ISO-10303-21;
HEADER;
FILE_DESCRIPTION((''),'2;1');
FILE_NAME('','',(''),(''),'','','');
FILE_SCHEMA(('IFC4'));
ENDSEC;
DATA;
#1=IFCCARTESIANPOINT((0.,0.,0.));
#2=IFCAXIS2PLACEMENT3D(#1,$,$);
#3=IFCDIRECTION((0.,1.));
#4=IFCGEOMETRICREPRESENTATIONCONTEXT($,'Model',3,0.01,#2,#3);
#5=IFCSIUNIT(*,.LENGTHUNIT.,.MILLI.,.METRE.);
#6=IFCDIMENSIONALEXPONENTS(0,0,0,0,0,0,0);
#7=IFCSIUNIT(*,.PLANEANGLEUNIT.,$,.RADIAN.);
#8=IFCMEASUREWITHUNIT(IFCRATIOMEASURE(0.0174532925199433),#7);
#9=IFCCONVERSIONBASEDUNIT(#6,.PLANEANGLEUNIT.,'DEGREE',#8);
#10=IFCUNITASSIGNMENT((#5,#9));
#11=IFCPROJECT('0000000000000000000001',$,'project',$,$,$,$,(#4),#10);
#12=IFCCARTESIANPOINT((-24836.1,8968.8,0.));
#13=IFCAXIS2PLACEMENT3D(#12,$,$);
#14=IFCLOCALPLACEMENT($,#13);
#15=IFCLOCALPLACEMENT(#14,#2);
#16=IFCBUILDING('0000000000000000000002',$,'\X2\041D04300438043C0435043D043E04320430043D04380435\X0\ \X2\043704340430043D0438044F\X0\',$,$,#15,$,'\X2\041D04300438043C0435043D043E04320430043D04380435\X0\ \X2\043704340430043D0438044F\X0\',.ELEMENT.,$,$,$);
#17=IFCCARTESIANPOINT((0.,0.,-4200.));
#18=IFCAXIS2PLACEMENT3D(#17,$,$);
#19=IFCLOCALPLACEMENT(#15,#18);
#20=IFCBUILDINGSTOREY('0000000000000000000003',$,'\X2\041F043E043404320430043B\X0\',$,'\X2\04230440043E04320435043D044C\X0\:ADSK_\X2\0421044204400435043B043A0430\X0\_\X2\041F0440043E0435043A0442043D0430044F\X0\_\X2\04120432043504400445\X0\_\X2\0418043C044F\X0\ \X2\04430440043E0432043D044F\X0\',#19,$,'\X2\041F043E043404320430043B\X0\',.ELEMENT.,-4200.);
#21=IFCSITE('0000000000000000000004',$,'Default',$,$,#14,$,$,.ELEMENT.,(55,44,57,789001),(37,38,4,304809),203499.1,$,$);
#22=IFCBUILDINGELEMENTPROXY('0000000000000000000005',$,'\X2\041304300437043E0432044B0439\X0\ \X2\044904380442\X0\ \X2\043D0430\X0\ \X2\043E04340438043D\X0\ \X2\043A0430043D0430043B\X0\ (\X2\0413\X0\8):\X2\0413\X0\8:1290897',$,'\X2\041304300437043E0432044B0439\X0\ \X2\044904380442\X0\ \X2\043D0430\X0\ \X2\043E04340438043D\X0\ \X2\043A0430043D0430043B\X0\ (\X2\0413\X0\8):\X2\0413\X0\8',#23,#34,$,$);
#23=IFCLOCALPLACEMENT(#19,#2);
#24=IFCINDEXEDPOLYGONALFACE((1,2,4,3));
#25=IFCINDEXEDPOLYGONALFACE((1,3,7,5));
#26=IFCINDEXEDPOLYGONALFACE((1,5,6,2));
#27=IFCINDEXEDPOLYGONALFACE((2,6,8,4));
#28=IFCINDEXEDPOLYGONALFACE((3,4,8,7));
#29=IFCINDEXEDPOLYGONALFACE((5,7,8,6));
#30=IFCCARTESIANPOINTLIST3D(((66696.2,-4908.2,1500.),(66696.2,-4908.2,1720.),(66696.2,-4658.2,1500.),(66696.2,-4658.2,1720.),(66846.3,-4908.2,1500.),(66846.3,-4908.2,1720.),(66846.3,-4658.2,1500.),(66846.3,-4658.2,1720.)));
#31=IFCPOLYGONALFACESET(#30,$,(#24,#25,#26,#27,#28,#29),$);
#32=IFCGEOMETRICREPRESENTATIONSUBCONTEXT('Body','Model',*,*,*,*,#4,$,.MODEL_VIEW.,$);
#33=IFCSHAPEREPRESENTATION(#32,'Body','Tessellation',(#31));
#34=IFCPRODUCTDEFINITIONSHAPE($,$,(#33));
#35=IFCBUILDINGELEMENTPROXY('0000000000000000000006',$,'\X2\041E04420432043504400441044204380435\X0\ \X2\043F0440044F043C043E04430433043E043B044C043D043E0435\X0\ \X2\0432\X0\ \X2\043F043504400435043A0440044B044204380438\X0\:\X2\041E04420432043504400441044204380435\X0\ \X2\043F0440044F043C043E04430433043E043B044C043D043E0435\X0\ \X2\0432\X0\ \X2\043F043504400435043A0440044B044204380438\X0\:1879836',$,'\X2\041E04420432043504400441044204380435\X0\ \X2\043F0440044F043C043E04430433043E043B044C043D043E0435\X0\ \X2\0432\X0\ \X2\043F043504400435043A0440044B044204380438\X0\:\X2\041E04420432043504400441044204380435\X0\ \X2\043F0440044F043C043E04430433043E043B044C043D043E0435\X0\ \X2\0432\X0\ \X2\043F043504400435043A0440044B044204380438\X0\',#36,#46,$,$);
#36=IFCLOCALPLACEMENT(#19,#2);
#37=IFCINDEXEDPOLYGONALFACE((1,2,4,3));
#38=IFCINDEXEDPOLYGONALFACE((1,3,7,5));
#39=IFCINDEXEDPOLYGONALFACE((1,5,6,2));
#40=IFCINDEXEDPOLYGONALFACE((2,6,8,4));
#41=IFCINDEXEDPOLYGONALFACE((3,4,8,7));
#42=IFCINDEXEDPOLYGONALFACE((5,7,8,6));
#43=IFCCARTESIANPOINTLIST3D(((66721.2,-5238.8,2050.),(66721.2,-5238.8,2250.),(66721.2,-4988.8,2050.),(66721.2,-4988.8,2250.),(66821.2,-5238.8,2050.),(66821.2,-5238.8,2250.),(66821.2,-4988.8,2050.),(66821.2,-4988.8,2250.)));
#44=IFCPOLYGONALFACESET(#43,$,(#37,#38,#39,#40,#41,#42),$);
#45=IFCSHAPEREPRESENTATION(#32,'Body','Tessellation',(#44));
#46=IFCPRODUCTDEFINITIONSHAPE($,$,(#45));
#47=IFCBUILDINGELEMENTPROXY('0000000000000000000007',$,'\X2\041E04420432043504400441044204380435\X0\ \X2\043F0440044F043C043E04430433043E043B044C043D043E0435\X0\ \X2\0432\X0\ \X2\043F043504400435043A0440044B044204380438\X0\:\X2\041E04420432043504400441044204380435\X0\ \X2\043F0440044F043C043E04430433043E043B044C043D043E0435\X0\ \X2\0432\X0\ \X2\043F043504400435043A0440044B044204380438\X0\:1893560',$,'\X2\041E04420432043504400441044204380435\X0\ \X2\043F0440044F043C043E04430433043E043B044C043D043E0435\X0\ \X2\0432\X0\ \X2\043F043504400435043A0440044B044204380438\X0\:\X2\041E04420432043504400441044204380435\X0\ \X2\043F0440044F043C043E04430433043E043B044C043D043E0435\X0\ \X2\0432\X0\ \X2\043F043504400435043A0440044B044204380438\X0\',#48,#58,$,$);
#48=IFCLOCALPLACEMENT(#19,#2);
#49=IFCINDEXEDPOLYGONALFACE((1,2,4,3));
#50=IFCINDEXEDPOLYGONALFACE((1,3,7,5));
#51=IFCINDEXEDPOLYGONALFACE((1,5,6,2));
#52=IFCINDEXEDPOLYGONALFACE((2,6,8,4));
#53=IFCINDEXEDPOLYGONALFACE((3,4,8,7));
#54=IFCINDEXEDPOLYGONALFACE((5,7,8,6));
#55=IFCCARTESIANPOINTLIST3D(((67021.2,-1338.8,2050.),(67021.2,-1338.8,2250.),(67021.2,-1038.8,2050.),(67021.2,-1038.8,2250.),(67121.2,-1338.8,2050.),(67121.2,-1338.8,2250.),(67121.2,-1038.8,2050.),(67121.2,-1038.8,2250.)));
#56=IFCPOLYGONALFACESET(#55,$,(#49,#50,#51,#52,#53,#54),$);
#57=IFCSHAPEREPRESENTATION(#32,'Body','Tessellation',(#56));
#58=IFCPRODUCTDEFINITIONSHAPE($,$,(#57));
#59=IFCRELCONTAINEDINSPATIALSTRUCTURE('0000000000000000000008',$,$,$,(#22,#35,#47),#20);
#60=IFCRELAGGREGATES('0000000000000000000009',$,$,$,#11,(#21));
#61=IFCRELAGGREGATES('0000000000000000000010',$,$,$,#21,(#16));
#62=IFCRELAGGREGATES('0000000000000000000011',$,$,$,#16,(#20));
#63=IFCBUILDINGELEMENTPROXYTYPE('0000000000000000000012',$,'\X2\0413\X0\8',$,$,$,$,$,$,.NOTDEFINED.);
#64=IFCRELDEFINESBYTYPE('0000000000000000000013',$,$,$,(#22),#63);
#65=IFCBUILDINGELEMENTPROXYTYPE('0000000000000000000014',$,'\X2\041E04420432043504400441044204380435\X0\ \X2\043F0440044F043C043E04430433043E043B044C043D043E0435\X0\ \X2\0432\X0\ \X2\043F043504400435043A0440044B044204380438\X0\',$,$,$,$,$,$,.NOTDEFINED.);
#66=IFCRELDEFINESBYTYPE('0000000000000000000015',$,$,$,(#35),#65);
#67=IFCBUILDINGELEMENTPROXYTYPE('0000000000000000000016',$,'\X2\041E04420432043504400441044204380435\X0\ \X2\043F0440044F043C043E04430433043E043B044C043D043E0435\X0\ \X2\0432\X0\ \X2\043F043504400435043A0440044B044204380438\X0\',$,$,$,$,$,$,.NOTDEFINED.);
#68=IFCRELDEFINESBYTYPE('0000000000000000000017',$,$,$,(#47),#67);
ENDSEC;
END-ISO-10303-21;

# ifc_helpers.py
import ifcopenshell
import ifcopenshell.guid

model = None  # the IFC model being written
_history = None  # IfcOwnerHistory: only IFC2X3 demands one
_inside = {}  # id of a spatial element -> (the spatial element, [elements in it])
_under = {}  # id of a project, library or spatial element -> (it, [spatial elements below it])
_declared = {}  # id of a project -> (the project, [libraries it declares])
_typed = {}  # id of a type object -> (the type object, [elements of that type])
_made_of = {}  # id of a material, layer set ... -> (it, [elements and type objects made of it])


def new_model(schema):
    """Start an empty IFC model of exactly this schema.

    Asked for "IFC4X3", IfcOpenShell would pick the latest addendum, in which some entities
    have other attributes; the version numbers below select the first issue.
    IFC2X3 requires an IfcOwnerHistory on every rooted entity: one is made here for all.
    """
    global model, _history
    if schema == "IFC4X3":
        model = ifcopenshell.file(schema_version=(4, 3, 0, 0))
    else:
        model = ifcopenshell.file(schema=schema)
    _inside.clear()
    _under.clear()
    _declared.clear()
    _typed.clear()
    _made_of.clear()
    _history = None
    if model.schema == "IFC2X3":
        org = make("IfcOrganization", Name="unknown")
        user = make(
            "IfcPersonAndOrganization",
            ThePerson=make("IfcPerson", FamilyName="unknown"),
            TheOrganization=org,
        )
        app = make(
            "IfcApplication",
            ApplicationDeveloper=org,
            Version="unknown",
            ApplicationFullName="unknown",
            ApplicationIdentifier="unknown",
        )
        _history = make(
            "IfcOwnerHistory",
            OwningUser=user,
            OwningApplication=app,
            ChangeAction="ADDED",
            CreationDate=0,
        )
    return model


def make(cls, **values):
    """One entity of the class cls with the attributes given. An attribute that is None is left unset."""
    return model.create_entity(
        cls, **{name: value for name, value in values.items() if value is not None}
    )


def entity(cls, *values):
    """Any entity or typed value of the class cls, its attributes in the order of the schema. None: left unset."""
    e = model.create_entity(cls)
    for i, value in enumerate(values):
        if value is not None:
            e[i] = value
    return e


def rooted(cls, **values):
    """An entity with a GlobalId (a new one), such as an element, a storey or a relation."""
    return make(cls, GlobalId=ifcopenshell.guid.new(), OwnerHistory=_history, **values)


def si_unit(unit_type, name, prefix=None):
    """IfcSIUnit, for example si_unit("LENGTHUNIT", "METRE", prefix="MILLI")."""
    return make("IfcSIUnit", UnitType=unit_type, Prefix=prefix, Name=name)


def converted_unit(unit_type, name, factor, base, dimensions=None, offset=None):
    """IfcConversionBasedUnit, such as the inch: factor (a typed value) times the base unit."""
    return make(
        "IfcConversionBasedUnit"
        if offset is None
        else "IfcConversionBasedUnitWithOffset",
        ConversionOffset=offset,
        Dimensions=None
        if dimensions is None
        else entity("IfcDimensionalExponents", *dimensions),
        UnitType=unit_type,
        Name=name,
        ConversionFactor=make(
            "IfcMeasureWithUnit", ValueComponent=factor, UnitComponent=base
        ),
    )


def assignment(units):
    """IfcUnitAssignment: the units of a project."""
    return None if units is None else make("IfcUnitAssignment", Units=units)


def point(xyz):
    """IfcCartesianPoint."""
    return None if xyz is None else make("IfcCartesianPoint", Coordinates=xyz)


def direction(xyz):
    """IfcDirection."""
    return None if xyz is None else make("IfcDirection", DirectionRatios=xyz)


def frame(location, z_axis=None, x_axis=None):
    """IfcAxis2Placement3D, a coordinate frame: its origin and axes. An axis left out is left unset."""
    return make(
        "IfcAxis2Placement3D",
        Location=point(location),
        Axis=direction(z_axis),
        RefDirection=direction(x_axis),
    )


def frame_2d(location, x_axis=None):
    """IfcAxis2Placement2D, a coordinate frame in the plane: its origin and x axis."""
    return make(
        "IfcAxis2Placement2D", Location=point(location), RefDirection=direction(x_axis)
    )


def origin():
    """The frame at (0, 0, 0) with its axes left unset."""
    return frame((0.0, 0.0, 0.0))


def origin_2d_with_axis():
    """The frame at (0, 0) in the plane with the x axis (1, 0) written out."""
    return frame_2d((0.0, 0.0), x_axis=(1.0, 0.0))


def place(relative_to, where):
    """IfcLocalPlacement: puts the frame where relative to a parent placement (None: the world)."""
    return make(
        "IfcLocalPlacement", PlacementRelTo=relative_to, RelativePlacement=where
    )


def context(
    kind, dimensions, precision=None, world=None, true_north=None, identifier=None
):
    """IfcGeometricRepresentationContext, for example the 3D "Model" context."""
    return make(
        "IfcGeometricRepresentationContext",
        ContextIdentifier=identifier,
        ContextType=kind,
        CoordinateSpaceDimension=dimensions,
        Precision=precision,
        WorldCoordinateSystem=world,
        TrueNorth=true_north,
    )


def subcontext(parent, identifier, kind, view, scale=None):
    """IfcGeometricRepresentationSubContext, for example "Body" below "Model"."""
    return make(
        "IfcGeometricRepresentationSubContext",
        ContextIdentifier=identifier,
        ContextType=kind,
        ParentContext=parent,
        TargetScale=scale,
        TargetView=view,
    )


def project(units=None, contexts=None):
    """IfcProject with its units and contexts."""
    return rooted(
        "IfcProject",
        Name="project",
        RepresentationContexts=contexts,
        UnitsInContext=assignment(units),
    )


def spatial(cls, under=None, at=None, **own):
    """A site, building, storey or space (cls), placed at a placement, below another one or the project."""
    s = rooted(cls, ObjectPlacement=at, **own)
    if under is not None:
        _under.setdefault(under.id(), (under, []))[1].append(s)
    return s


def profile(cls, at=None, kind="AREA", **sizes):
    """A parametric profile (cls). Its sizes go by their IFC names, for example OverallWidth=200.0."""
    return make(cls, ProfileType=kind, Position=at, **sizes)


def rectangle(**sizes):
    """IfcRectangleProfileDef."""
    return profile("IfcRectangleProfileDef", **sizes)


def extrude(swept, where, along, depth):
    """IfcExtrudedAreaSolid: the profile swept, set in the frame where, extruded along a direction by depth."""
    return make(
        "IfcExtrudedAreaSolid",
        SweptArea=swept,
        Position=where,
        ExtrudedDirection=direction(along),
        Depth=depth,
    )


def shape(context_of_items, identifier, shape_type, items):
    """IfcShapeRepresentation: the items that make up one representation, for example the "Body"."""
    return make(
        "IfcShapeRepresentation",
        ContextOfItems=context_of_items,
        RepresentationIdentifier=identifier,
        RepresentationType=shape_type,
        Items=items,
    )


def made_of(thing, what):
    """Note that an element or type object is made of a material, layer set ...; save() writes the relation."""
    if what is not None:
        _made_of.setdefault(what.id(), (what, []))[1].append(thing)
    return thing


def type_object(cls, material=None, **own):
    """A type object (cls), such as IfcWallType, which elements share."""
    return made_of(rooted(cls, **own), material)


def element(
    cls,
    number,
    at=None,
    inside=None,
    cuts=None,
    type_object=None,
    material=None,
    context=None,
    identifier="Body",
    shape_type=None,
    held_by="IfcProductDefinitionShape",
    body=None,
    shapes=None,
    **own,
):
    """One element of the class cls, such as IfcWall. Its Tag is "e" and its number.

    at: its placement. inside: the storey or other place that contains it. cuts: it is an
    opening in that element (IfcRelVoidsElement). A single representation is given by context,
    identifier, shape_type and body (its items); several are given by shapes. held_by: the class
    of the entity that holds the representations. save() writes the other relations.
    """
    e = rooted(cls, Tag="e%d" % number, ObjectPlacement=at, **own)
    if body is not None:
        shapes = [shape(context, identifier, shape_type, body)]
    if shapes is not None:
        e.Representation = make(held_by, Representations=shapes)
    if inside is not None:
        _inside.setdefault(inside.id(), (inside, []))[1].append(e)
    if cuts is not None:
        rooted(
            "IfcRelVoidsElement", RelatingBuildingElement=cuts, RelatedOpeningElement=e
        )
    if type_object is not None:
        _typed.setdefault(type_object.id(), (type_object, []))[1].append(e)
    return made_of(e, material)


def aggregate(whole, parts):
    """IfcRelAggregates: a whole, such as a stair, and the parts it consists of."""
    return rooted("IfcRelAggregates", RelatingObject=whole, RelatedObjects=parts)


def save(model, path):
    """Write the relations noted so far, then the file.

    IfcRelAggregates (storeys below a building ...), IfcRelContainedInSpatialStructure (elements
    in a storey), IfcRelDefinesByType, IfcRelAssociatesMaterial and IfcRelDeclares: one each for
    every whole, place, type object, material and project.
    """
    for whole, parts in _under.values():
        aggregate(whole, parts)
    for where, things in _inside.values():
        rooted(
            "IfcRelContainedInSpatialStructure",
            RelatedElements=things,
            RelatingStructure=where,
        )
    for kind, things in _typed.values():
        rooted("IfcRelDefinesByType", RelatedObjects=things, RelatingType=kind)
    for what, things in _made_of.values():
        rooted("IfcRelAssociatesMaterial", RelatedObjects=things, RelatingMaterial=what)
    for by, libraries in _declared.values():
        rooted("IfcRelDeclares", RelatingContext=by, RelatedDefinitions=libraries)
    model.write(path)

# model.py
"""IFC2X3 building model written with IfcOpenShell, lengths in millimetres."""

from ifc_helpers import new_model, entity, si_unit, converted_unit, direction, frame, origin, origin_2d_with_axis, place, context, subcontext, project, spatial, rectangle, extrude, type_object, element, save


model = new_model("IFC2X3")

# Units and contexts
model_context = context("Model", 3, precision=0.01, world=origin(), true_north=direction((0.0, 1.0)))
body_context = subcontext(model_context, "Body", "Model", "MODEL_VIEW")
ifc_project = project(units=[si_unit("LENGTHUNIT", "METRE", prefix="MILLI"), converted_unit("PLANEANGLEUNIT", "DEGREE", entity("IfcRatioMeasure", 0.0174532925199433), si_unit("PLANEANGLEUNIT", "RADIAN"), dimensions=[0, 0, 0, 0, 0, 0, 0])], contexts=[model_context])

# Site, building, storey
site_placement = place(None, frame((-24836.1, 8968.8, 0.0)))
site = spatial("IfcSite", under=ifc_project, at=site_placement, Name="Default", CompositionType="ELEMENT", RefLatitude=(55, 44, 57, 789001), RefLongitude=(37, 38, 4, 304809), RefElevation=203499.1)
building_placement = place(site_placement, origin())
building = spatial("IfcBuilding", under=site, at=building_placement, Name="Наименование здания", LongName="Наименование здания", CompositionType="ELEMENT")
storey_placement = place(building_placement, frame((0.0, 0.0, -4200.0)))
storey = spatial("IfcBuildingStorey", under=building, at=storey_placement, Name="Подвал", ObjectType="Уровень:ADSK_Стрелка_Проектная_Вверх_Имя уровня", LongName="Подвал", CompositionType="ELEMENT", Elevation=-4200.0)

# Building element proxies
building_element_proxy_type_1 = type_object("IfcBuildingElementProxyType", Name="Г8", PredefinedType="NOTDEFINED")
proxy_1_placement = place(storey_placement, frame((66696.2, -4908.1, 1500.0)))
element("IfcBuildingElementProxy", 1, at=proxy_1_placement, inside=storey, type_object=building_element_proxy_type_1, Name="Газовый щит на один канал (Г8):Г8:1290897", ObjectType="Газовый щит на один канал (Г8):Г8", context=body_context, shape_type="SweptSolid", body=[
    extrude(rectangle(XDim=250.0, YDim=150.0, at=origin_2d_with_axis()), frame((75.0, 125.0, 0.0), z_axis=(0.0, 0.0, 1.0), x_axis=(0.0, 1.0, 0.0)), (0.0, 0.0, 1.0), 220.0),
])
building_element_proxy_type_2 = type_object("IfcBuildingElementProxyType", Name="Отверстие прямоугольное в перекрытии", PredefinedType="NOTDEFINED")
proxy_2_placement = place(storey_placement, frame((66721.2, -5238.8, 2050.0)))
element("IfcBuildingElementProxy", 2, at=proxy_2_placement, inside=storey, type_object=building_element_proxy_type_2, Name="Отверстие прямоугольное в перекрытии:Отверстие прямоугольное в перекрытии:1879836", ObjectType="Отверстие прямоугольное в перекрытии:Отверстие прямоугольное в перекрытии", context=body_context, shape_type="SweptSolid", body=[
    extrude(rectangle(XDim=250.0, YDim=100.0, at=origin_2d_with_axis()), frame((50.0, 125.0, 0.0), z_axis=(0.0, 0.0, 1.0), x_axis=(0.0, -1.0, 0.0)), (0.0, 0.0, 1.0), 200.0),
])
building_element_proxy_type_3 = type_object("IfcBuildingElementProxyType", Name="Отверстие прямоугольное в перекрытии", PredefinedType="NOTDEFINED")
proxy_3_placement = place(storey_placement, frame((67021.2, -1338.8, 2050.0)))
element("IfcBuildingElementProxy", 3, at=proxy_3_placement, inside=storey, type_object=building_element_proxy_type_3, Name="Отверстие прямоугольное в перекрытии:Отверстие прямоугольное в перекрытии:1893560", ObjectType="Отверстие прямоугольное в перекрытии:Отверстие прямоугольное в перекрытии", context=body_context, shape_type="SweptSolid", body=[
    extrude(rectangle(XDim=300.0, YDim=100.0, at=origin_2d_with_axis()), frame((50.0, 150.0, 0.0), z_axis=(0.0, 0.0, 1.0), x_axis=(0.0, 1.0, 0.0)), (0.0, 0.0, 1.0), 200.0),
])

save(model, "model.ifc")
